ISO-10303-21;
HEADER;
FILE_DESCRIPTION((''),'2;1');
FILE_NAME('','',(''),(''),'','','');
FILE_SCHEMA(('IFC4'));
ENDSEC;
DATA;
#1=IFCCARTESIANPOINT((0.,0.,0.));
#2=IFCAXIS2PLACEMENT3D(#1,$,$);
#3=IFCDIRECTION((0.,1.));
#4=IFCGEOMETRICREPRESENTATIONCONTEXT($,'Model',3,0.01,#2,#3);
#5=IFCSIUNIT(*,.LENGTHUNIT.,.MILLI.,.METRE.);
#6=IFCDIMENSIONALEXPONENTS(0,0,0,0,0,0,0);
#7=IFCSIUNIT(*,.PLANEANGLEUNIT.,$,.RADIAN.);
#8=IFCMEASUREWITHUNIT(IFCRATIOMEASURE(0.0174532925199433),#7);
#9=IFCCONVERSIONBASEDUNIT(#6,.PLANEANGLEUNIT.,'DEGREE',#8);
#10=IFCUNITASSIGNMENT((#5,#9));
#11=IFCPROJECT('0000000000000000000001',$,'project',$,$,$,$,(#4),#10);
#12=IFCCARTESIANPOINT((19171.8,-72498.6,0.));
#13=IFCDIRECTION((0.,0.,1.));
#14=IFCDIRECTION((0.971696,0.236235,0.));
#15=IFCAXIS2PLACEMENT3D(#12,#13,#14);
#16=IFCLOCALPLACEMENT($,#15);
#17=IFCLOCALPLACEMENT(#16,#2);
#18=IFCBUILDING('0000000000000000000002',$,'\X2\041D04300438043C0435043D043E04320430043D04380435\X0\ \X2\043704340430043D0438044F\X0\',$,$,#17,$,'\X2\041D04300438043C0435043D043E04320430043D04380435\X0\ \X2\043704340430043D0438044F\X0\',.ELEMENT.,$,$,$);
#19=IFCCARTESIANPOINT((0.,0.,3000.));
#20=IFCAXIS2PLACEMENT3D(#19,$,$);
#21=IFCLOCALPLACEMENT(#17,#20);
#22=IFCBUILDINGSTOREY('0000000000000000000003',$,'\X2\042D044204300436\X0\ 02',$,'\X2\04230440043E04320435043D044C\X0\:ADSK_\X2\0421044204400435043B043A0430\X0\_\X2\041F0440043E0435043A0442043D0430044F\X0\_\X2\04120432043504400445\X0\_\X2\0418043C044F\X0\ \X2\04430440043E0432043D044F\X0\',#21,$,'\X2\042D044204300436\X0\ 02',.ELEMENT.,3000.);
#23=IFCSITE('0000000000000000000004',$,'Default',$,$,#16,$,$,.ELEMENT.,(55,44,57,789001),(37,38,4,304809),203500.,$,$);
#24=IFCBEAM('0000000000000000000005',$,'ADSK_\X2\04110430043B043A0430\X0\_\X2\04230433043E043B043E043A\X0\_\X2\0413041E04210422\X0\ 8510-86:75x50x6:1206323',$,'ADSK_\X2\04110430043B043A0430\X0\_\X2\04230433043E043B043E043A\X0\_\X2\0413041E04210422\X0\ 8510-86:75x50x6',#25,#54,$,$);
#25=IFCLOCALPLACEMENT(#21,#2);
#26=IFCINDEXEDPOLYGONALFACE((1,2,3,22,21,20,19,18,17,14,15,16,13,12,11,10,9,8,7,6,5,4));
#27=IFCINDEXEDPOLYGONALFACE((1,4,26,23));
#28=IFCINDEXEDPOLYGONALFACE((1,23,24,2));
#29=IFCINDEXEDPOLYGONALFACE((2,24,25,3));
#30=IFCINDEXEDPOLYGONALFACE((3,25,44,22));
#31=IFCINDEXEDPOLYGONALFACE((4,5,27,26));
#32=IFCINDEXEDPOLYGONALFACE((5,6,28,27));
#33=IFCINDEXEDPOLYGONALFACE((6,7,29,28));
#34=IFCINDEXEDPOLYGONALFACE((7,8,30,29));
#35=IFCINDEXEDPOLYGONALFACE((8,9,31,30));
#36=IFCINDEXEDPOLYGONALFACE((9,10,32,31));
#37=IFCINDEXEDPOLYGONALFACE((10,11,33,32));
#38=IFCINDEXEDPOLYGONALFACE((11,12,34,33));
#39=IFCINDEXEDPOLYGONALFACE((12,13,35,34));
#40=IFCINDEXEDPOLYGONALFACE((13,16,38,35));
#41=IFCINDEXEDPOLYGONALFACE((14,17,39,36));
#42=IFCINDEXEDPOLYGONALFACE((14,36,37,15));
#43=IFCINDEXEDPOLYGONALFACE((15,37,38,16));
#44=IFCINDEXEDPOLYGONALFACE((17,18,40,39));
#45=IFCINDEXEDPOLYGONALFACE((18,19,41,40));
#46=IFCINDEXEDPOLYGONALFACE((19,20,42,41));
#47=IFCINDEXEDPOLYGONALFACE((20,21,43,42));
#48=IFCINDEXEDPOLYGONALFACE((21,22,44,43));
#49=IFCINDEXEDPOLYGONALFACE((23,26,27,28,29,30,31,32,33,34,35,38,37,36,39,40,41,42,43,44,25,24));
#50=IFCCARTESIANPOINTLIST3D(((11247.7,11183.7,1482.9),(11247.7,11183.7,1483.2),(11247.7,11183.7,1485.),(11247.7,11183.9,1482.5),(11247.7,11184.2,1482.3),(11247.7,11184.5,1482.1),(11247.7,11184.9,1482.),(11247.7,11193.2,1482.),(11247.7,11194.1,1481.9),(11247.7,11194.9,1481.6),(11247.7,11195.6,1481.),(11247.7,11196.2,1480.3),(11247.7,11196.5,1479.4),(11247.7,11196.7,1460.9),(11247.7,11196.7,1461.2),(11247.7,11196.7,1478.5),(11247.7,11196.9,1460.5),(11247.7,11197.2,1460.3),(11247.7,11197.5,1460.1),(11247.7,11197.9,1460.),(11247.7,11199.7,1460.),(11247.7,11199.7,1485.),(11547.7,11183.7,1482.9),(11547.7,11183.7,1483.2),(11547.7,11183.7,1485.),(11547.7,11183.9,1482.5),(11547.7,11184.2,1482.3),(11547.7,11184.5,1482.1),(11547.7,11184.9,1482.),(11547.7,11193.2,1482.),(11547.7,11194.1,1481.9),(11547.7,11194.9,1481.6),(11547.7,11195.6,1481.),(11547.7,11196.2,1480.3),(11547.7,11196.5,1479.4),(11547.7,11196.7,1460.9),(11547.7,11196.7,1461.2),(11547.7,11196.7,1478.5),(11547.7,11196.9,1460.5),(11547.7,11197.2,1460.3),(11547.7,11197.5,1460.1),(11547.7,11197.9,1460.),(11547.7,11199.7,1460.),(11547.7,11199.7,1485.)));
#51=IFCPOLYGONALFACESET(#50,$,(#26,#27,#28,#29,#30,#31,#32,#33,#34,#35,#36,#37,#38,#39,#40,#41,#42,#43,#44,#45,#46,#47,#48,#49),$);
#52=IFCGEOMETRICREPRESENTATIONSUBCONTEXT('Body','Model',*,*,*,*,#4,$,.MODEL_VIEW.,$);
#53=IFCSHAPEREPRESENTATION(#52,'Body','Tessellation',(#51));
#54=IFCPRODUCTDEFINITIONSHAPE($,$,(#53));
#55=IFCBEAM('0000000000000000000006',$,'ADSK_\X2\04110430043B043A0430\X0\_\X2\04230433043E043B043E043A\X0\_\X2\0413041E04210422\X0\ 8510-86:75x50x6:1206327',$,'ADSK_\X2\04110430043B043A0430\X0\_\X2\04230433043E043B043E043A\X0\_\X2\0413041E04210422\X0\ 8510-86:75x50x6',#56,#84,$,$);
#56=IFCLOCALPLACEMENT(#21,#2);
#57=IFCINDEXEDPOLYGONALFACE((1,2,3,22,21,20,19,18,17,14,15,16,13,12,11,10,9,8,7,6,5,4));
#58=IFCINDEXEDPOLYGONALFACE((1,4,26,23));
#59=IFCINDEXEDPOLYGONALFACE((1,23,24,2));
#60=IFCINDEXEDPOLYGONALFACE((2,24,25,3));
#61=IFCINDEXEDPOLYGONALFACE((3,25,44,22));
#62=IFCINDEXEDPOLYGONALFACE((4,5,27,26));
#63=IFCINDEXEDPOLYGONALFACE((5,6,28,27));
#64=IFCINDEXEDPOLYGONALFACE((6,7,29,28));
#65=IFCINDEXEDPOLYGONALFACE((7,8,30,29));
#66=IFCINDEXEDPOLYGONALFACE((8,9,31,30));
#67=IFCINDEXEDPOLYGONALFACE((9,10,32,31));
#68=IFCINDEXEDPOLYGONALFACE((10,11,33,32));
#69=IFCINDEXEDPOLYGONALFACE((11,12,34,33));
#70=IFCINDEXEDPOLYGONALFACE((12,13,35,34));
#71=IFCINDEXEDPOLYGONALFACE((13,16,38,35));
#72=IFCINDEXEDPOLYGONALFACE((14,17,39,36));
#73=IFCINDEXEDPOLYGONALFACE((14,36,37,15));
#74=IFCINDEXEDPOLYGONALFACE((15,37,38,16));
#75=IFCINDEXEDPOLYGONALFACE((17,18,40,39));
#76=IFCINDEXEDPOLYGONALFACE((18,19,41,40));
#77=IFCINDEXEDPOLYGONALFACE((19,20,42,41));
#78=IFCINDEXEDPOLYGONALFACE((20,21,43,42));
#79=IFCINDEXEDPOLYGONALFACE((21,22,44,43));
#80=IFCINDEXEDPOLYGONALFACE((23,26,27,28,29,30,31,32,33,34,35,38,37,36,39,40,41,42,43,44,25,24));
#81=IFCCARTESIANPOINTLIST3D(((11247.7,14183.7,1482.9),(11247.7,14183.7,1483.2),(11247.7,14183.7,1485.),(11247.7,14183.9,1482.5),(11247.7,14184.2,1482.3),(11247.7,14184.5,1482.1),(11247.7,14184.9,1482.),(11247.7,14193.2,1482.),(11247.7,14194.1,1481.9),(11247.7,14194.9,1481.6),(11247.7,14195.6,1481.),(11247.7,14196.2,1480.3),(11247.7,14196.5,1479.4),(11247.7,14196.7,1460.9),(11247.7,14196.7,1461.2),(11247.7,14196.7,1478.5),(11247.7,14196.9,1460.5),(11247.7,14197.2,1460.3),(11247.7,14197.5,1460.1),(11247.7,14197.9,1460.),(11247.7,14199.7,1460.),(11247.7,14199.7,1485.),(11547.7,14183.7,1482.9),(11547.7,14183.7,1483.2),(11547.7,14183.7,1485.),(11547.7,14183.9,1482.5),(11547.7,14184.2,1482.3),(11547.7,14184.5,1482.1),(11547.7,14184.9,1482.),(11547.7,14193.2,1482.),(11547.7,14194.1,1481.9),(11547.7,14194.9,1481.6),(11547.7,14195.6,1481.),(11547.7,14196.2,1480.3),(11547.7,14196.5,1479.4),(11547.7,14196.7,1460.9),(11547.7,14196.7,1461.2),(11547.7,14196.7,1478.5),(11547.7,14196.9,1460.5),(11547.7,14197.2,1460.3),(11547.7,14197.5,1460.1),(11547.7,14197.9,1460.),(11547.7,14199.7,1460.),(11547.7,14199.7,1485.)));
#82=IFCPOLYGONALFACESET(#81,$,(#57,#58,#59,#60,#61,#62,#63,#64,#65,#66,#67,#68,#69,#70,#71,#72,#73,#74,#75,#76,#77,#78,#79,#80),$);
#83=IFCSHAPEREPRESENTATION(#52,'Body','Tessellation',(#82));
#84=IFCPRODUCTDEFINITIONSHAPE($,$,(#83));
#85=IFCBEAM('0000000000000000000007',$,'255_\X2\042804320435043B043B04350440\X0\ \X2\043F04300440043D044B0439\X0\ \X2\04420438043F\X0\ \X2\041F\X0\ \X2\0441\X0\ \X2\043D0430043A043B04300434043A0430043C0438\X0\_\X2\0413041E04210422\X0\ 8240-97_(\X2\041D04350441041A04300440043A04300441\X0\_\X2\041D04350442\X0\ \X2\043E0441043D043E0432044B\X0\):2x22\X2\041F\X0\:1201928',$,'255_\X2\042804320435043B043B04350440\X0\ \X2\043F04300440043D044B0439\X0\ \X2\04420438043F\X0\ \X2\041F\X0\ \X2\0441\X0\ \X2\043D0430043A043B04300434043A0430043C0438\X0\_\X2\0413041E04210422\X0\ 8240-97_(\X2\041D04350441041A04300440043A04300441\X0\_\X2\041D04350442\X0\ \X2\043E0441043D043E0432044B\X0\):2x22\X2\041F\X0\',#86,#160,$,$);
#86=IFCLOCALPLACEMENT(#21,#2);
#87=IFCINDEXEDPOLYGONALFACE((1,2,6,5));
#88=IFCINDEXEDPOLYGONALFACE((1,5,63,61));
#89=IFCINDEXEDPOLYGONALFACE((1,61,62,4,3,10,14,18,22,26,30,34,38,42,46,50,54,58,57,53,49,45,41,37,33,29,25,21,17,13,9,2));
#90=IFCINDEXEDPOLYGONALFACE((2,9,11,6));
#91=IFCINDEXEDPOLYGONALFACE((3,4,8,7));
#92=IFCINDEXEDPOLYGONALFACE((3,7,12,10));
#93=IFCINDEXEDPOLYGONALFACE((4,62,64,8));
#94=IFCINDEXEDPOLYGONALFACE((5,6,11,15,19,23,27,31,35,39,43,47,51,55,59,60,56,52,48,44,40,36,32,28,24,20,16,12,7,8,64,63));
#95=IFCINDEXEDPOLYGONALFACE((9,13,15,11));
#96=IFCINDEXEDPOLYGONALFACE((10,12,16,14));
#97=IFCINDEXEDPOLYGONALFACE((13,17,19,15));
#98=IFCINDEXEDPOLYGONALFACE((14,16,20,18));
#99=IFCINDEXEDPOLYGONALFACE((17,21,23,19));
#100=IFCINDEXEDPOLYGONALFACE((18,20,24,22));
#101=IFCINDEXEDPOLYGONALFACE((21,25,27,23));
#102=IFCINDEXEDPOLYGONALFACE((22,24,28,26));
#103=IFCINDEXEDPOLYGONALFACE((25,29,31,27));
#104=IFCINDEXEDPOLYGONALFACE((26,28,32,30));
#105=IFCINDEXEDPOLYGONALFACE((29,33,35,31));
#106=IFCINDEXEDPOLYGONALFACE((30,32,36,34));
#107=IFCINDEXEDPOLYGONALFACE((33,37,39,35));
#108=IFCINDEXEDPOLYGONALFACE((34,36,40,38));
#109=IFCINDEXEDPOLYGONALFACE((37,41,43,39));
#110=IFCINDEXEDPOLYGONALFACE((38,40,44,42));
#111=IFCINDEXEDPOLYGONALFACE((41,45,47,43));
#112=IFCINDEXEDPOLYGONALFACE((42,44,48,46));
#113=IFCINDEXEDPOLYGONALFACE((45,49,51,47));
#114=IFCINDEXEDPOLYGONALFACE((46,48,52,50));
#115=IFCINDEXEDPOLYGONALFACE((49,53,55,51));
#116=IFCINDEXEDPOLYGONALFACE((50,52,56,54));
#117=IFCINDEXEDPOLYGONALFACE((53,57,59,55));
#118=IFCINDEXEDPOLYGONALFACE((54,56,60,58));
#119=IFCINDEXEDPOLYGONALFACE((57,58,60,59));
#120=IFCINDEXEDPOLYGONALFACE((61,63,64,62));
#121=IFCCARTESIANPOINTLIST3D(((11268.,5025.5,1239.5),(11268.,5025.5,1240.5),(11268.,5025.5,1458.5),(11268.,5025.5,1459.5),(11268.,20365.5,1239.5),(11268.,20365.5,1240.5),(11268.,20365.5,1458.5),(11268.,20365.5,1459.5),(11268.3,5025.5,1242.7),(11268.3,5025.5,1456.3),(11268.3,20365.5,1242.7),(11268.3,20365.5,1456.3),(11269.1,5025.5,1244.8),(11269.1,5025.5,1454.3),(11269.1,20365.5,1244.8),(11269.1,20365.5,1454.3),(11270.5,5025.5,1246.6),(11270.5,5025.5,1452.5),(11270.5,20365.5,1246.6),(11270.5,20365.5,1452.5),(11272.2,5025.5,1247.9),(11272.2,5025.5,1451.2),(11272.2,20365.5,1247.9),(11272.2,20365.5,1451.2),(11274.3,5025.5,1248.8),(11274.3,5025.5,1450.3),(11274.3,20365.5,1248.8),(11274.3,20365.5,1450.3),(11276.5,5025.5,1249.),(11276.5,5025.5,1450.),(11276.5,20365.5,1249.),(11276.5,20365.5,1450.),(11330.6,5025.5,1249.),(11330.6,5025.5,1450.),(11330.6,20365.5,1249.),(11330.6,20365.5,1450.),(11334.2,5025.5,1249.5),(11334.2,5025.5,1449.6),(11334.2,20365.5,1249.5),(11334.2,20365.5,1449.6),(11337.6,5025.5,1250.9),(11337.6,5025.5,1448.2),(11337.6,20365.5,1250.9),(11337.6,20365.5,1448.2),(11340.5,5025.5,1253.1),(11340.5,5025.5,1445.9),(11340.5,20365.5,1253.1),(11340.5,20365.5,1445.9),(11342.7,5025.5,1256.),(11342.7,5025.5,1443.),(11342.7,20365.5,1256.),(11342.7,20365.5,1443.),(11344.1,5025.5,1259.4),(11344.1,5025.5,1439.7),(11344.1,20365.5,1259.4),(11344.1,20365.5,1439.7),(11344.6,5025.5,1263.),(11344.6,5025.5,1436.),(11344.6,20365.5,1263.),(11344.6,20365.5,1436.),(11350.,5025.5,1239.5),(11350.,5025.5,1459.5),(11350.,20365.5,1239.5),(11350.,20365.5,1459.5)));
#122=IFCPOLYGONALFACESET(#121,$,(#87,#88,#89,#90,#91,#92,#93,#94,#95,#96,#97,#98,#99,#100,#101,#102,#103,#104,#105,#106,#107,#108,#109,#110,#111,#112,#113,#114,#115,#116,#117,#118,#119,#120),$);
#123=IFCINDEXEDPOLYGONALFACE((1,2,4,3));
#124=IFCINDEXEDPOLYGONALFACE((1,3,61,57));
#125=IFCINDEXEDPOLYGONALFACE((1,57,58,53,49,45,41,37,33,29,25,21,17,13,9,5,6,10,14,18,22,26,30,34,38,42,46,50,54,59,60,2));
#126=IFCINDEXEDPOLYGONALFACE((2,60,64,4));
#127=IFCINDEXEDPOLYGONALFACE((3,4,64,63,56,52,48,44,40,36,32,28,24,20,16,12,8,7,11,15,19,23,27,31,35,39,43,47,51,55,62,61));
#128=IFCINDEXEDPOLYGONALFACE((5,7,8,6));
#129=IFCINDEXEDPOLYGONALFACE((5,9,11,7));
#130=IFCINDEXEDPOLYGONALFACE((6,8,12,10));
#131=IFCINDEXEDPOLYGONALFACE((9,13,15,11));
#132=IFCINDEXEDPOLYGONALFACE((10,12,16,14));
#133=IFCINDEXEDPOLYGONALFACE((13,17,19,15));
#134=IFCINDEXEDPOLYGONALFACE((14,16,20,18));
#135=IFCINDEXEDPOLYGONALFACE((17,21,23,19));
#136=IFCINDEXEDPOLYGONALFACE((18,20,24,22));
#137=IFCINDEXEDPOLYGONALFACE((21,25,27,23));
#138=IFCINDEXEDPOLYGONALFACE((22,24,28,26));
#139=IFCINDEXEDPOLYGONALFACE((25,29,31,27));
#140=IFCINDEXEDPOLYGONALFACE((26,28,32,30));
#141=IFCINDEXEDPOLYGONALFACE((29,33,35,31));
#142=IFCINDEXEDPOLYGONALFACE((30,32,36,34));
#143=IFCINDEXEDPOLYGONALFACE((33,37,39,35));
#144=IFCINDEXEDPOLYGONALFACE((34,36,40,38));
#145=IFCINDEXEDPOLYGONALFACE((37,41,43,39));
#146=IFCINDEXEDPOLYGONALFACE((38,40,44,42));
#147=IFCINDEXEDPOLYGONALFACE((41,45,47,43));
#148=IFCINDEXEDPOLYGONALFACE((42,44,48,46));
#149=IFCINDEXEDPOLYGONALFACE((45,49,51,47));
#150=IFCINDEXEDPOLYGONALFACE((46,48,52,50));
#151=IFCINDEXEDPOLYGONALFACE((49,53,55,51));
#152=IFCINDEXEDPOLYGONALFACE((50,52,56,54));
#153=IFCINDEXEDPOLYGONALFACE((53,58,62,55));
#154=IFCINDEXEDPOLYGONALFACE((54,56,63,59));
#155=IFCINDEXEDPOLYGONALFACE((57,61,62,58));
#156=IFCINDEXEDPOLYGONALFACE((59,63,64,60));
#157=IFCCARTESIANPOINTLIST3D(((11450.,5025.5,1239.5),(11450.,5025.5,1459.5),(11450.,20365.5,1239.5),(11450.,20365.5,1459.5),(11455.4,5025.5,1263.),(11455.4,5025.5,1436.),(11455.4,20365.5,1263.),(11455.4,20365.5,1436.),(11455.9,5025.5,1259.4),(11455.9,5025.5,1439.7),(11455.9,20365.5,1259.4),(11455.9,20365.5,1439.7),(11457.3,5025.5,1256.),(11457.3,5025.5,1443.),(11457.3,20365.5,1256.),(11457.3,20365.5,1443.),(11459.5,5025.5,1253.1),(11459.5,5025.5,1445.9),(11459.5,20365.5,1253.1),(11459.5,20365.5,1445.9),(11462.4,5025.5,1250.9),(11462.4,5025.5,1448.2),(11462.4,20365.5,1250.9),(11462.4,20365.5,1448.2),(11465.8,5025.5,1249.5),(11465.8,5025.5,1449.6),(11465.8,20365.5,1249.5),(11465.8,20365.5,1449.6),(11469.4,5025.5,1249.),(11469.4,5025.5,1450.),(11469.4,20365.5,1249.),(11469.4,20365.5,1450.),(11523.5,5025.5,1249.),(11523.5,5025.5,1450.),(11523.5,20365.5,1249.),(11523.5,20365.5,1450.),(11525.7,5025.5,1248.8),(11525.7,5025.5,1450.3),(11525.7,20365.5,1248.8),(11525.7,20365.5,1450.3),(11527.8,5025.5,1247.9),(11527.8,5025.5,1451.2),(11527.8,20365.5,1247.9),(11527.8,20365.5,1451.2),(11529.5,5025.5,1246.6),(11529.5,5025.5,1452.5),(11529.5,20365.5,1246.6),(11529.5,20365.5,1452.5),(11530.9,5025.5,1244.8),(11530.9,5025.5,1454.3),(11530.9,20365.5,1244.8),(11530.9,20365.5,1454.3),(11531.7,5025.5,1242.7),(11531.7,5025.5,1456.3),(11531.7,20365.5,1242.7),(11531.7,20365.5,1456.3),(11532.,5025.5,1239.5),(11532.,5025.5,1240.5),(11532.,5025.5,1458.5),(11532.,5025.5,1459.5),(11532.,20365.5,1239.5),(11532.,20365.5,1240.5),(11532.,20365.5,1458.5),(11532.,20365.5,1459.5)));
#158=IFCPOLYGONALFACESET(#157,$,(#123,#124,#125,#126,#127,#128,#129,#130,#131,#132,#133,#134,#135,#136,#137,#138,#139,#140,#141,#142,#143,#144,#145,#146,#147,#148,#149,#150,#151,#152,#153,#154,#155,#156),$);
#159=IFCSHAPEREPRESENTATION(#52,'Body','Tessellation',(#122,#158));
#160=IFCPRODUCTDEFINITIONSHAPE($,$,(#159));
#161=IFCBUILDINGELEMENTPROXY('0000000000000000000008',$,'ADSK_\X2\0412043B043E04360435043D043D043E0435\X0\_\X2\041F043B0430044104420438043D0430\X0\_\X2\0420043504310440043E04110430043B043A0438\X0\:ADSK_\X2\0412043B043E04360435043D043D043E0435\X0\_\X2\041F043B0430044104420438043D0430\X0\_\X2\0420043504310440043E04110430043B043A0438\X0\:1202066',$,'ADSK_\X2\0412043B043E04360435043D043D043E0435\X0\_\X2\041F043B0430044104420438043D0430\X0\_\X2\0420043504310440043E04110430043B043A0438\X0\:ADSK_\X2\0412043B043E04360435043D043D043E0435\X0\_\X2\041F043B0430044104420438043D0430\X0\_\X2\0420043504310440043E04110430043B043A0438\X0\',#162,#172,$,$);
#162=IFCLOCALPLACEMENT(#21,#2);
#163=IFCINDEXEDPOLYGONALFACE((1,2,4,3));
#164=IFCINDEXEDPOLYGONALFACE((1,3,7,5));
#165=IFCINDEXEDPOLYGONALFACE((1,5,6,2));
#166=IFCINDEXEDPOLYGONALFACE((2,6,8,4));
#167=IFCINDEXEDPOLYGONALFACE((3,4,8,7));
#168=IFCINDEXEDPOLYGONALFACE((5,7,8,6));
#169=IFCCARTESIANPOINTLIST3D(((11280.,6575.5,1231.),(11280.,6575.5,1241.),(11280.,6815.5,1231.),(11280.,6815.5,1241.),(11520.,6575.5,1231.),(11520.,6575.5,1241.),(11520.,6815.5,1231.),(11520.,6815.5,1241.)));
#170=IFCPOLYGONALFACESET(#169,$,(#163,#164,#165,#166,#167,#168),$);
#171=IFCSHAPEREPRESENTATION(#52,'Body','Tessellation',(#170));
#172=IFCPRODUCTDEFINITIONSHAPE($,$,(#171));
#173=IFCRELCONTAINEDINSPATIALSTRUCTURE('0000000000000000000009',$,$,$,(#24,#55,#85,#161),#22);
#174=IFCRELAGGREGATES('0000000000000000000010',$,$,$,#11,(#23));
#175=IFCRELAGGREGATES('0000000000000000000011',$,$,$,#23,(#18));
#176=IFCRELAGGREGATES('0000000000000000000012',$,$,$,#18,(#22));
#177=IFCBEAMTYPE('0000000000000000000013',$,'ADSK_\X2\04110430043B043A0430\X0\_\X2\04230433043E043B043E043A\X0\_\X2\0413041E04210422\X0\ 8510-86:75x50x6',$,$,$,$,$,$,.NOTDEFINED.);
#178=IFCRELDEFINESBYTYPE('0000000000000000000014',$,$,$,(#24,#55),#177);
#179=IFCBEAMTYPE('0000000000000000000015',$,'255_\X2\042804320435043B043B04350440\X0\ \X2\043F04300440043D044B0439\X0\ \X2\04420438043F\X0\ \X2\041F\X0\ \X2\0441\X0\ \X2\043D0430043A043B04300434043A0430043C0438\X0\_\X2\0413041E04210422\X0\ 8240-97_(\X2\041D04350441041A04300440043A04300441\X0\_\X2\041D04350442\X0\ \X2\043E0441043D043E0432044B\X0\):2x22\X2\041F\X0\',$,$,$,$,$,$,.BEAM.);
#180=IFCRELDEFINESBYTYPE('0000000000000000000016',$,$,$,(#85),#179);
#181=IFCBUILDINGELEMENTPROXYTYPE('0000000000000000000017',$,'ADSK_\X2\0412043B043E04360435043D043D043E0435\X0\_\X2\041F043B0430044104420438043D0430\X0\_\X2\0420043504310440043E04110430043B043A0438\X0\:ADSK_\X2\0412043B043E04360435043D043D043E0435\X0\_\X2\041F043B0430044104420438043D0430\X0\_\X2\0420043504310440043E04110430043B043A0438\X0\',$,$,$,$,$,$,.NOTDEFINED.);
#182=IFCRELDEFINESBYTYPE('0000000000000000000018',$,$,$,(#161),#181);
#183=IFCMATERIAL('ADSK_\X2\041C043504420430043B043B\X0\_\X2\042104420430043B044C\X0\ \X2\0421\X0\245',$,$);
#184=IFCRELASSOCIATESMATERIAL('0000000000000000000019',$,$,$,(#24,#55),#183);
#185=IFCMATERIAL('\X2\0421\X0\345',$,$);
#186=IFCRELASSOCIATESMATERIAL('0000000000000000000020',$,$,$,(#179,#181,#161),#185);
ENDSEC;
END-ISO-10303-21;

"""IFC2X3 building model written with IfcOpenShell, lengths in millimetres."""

from ifc_helpers import new_model, entity, si_unit, converted_unit, direction, frame, frame_2d, origin, origin_2d_with_axis, place, context, subcontext, project, spatial, polyline, circle_curve, parameter, trimmed, segment, composite_curve, rectangle, outline, extrude, source, transform, mapped, material, type_object, type_shapes, element, save


model = new_model("IFC2X3")

# Units and contexts
model_context = context("Model", 3, precision=0.01, world=origin(), true_north=direction((0.0, 1.0)))
body_context = subcontext(model_context, "Body", "Model", "MODEL_VIEW")
ifc_project = project(units=[si_unit("LENGTHUNIT", "METRE", prefix="MILLI"), converted_unit("PLANEANGLEUNIT", "DEGREE", entity("IfcRatioMeasure", 0.0174532925199433), si_unit("PLANEANGLEUNIT", "RADIAN"), dimensions=[0, 0, 0, 0, 0, 0, 0])], contexts=[model_context])

# Site, building, storey
site_placement = place(None, frame((19171.8, -72498.6, 0.0), z_axis=(0.0, 0.0, 1.0), x_axis=(0.971696, 0.236235, 0.0)))
site = spatial("IfcSite", under=ifc_project, at=site_placement, Name="Default", CompositionType="ELEMENT", RefLatitude=(55, 44, 57, 789001), RefLongitude=(37, 38, 4, 304809), RefElevation=203500.0)
building_placement = place(site_placement, origin())
building = spatial("IfcBuilding", under=site, at=building_placement, Name="Наименование здания", LongName="Наименование здания", CompositionType="ELEMENT")
storey_placement = place(building_placement, frame((0.0, 0.0, 3000.0)))
storey = spatial("IfcBuildingStorey", under=building, at=storey_placement, Name="Этаж 02", ObjectType="Уровень:ADSK_Стрелка_Проектная_Вверх_Имя уровня", LongName="Этаж 02", CompositionType="ELEMENT", Elevation=3000.0)

# Beams
ifc_material_1 = material(Name="ADSK_Металл_Сталь С245")
beam_type_1 = type_object("IfcBeamType", Name="ADSK_Балка_Уголок_ГОСТ 8510-86:75x50x6", PredefinedType="NOTDEFINED")
for number, where, name in (
    (1, (11247.7, 11195.5, 1460.0), "ADSK_Балка_Уголок_ГОСТ 8510-86:75x50x6:1206323"),
    (2, (11247.7, 14195.5, 1460.0), "ADSK_Балка_Уголок_ГОСТ 8510-86:75x50x6:1206327"),
):
    element("IfcBeam", number, at=place(storey_placement, frame(where)), inside=storey, type_object=beam_type_1, material=ifc_material_1, Name=name, ObjectType="ADSK_Балка_Уголок_ГОСТ 8510-86:75x50x6", context=body_context, shape_type="SweptSolid", body=[
        extrude(outline(composite_curve([segment(polyline([(-9.8, -9.2), (-8.0, -9.2)]), True, "CONTINUOUS"), segment(trimmed(circle_curve(frame_2d((-8.0, -8.0), x_axis=(0.0, -1.0)), 1.2), [parameter(0.0)], [parameter(90.0)], True, "PARAMETER"), True, "CONTINUOUS"), segment(polyline([(-6.8, -8.0), (-6.8, 0.3)]), True, "CONTINUOUS"), segment(trimmed(circle_curve(frame_2d((-3.3, 0.3), x_axis=(-1.0, 0.0)), 3.5), [parameter(270.0)], [parameter(0.0)], True, "PARAMETER"), False, "CONTINUOUS"), segment(polyline([(-3.3, 3.8), (14.0, 3.8)]), True, "CONTINUOUS"), segment(trimmed(circle_curve(frame_2d((14.0, 5.0), x_axis=(0.0, -1.0)), 1.2), [parameter(0.0)], [parameter(90.0)], True, "PARAMETER"), True, "CONTINUOUS"), segment(polyline([(15.2, 5.0), (15.2, 6.8)]), True, "CONTINUOUS"), segment(polyline([(15.2, 6.8), (-9.8, 6.8)]), True, "CONTINUOUS"), segment(polyline([(-9.8, 6.8), (-9.8, -9.2)]), True, "CONTINUOUS")], self_intersect=False)), frame((0.0, -2.6, 15.2), z_axis=(1.0, 0.0, 0.0), x_axis=(0.0, 0.0, -1.0)), (0.0, 0.0, 1.0), 300.0),
    ])
ifc_material_2 = material(Name="С345")
beam_type_2 = type_object("IfcBeamType", Name="255_Швеллер парный тип П с накладками_ГОСТ 8240-97_(НесКаркас_Нет основы):2x22П", PredefinedType="BEAM", material=ifc_material_2)
shared_shape_1 = source(origin(), body_context, "Body", "SweptSolid", [
    extrude(outline(composite_curve([segment(polyline([(-110.0, -43.7), (110.0, -43.7)]), True, "CONTINUOUS"), segment(polyline([(110.0, -43.7), (110.0, 38.3)]), True, "CONTINUOUS"), segment(polyline([(110.0, 38.3), (109.0, 38.3)]), True, "CONTINUOUS"), segment(trimmed(circle_curve(frame_2d((109.0, 29.8), x_axis=(0.0, 1.0)), 8.5), [parameter(0.0)], [parameter(90.0)], True, "PARAMETER"), True, "CONTINUOUS"), segment(polyline([(100.5, 29.8), (100.5, -24.3)]), True, "CONTINUOUS"), segment(trimmed(circle_curve(frame_2d((86.5, -24.3), x_axis=(1.0, 0.0)), 14.0), [parameter(270.0)], [parameter(0.0)], True, "PARAMETER"), False, "CONTINUOUS"), segment(polyline([(86.5, -38.3), (-86.5, -38.3)]), True, "CONTINUOUS"), segment(trimmed(circle_curve(frame_2d((-86.5, -24.3), x_axis=(0.0, -1.0)), 14.0), [parameter(270.0)], [parameter(0.0)], True, "PARAMETER"), False, "CONTINUOUS"), segment(polyline([(-100.5, -24.3), (-100.5, 29.8)]), True, "CONTINUOUS"), segment(trimmed(circle_curve(frame_2d((-109.0, 29.8), x_axis=(1.0, 0.0)), 8.5), [parameter(0.0)], [parameter(90.0)], True, "PARAMETER"), True, "CONTINUOUS"), segment(polyline([(-109.0, 38.3), (-110.0, 38.3)]), True, "CONTINUOUS"), segment(polyline([(-110.0, 38.3), (-110.0, -43.7)]), True, "CONTINUOUS")], self_intersect=False)), frame((-7670.0, 93.7, 0.0), z_axis=(1.0, 0.0, 0.0), x_axis=(0.0, 0.0, -1.0)), (0.0, 0.0, 1.0), 15340.0),
    extrude(outline(composite_curve([segment(polyline([(-110.0, -38.3), (-109.0, -38.3)]), True, "CONTINUOUS"), segment(trimmed(circle_curve(frame_2d((-109.0, -29.8), x_axis=(0.0, -1.0)), 8.5), [parameter(0.0)], [parameter(90.0)], True, "PARAMETER"), True, "CONTINUOUS"), segment(polyline([(-100.5, -29.8), (-100.5, 24.3)]), True, "CONTINUOUS"), segment(trimmed(circle_curve(frame_2d((-86.5, 24.3), x_axis=(-1.0, 0.0)), 14.0), [parameter(270.0)], [parameter(0.0)], True, "PARAMETER"), False, "CONTINUOUS"), segment(polyline([(-86.5, 38.3), (86.5, 38.3)]), True, "CONTINUOUS"), segment(trimmed(circle_curve(frame_2d((86.5, 24.3), x_axis=(0.0, 1.0)), 14.0), [parameter(270.0)], [parameter(0.0)], True, "PARAMETER"), False, "CONTINUOUS"), segment(polyline([(100.5, 24.3), (100.5, -29.8)]), True, "CONTINUOUS"), segment(trimmed(circle_curve(frame_2d((109.0, -29.8), x_axis=(-1.0, 0.0)), 8.5), [parameter(0.0)], [parameter(90.0)], True, "PARAMETER"), True, "CONTINUOUS"), segment(polyline([(109.0, -38.3), (110.0, -38.3)]), True, "CONTINUOUS"), segment(polyline([(110.0, -38.3), (110.0, 43.7)]), True, "CONTINUOUS"), segment(polyline([(110.0, 43.7), (-110.0, 43.7)]), True, "CONTINUOUS"), segment(polyline([(-110.0, 43.7), (-110.0, -38.3)]), True, "CONTINUOUS")], self_intersect=False)), frame((-7670.0, -93.7, 0.0), z_axis=(1.0, 0.0, 0.0), x_axis=(0.0, 0.0, -1.0)), (0.0, 0.0, 1.0), 15340.0),
])
type_shapes(beam_type_2, [shared_shape_1])
beam_1_placement = place(storey_placement, frame((11400.0, 12695.5, 1349.5), z_axis=(0.0, 0.0, 1.0), x_axis=(0.0, 1.0, 0.0)))
element("IfcBeam", 3, at=beam_1_placement, inside=storey, type_object=beam_type_2, Name="255_Швеллер парный тип П с накладками_ГОСТ 8240-97_(НесКаркас_Нет основы):2x22П:1201928", ObjectType="255_Швеллер парный тип П с накладками_ГОСТ 8240-97_(НесКаркас_Нет основы):2x22П", context=body_context, shape_type="MappedRepresentation", body=[
    mapped(shared_shape_1, transform((0.0, 0.0, 0.0), scale=1.0)),
])

# Building element proxy
building_element_proxy_type = type_object("IfcBuildingElementProxyType", Name="ADSK_Вложенное_Пластина_РеброБалки:ADSK_Вложенное_Пластина_РеброБалки", PredefinedType="NOTDEFINED", material=ifc_material_2)
shared_shape_2 = source(origin(), body_context, "Body", "SweptSolid", [
    extrude(rectangle(XDim=10.0, YDim=240.0, at=origin_2d_with_axis()), frame((0.0, 0.0, -120.0), z_axis=(0.0, 0.0, 1.0), x_axis=(0.0, 1.0, 0.0)), (0.0, 0.0, 1.0), 240.0),
])
type_shapes(building_element_proxy_type, [shared_shape_2])
for number, where, z_axis, x_axis, name in (
    (4, (11400.0, 6695.5, 1236.0), (0.0, 1.0, 0.0), (1.0, 0.0, 0.0), "ADSK_Вложенное_Пластина_РеброБалки:ADSK_Вложенное_Пластина_РеброБалки:1202066"),
):
    element("IfcBuildingElementProxy", number, at=place(storey_placement, frame(where, z_axis=z_axis, x_axis=x_axis)), inside=storey, type_object=building_element_proxy_type, material=ifc_material_2, Name=name, ObjectType="ADSK_Вложенное_Пластина_РеброБалки:ADSK_Вложенное_Пластина_РеброБалки", context=body_context, shape_type="MappedRepresentation", body=[
        mapped(shared_shape_2, transform((0.0, 0.0, 0.0), scale=1.0)),
    ])

save(model, "model.ifc")
